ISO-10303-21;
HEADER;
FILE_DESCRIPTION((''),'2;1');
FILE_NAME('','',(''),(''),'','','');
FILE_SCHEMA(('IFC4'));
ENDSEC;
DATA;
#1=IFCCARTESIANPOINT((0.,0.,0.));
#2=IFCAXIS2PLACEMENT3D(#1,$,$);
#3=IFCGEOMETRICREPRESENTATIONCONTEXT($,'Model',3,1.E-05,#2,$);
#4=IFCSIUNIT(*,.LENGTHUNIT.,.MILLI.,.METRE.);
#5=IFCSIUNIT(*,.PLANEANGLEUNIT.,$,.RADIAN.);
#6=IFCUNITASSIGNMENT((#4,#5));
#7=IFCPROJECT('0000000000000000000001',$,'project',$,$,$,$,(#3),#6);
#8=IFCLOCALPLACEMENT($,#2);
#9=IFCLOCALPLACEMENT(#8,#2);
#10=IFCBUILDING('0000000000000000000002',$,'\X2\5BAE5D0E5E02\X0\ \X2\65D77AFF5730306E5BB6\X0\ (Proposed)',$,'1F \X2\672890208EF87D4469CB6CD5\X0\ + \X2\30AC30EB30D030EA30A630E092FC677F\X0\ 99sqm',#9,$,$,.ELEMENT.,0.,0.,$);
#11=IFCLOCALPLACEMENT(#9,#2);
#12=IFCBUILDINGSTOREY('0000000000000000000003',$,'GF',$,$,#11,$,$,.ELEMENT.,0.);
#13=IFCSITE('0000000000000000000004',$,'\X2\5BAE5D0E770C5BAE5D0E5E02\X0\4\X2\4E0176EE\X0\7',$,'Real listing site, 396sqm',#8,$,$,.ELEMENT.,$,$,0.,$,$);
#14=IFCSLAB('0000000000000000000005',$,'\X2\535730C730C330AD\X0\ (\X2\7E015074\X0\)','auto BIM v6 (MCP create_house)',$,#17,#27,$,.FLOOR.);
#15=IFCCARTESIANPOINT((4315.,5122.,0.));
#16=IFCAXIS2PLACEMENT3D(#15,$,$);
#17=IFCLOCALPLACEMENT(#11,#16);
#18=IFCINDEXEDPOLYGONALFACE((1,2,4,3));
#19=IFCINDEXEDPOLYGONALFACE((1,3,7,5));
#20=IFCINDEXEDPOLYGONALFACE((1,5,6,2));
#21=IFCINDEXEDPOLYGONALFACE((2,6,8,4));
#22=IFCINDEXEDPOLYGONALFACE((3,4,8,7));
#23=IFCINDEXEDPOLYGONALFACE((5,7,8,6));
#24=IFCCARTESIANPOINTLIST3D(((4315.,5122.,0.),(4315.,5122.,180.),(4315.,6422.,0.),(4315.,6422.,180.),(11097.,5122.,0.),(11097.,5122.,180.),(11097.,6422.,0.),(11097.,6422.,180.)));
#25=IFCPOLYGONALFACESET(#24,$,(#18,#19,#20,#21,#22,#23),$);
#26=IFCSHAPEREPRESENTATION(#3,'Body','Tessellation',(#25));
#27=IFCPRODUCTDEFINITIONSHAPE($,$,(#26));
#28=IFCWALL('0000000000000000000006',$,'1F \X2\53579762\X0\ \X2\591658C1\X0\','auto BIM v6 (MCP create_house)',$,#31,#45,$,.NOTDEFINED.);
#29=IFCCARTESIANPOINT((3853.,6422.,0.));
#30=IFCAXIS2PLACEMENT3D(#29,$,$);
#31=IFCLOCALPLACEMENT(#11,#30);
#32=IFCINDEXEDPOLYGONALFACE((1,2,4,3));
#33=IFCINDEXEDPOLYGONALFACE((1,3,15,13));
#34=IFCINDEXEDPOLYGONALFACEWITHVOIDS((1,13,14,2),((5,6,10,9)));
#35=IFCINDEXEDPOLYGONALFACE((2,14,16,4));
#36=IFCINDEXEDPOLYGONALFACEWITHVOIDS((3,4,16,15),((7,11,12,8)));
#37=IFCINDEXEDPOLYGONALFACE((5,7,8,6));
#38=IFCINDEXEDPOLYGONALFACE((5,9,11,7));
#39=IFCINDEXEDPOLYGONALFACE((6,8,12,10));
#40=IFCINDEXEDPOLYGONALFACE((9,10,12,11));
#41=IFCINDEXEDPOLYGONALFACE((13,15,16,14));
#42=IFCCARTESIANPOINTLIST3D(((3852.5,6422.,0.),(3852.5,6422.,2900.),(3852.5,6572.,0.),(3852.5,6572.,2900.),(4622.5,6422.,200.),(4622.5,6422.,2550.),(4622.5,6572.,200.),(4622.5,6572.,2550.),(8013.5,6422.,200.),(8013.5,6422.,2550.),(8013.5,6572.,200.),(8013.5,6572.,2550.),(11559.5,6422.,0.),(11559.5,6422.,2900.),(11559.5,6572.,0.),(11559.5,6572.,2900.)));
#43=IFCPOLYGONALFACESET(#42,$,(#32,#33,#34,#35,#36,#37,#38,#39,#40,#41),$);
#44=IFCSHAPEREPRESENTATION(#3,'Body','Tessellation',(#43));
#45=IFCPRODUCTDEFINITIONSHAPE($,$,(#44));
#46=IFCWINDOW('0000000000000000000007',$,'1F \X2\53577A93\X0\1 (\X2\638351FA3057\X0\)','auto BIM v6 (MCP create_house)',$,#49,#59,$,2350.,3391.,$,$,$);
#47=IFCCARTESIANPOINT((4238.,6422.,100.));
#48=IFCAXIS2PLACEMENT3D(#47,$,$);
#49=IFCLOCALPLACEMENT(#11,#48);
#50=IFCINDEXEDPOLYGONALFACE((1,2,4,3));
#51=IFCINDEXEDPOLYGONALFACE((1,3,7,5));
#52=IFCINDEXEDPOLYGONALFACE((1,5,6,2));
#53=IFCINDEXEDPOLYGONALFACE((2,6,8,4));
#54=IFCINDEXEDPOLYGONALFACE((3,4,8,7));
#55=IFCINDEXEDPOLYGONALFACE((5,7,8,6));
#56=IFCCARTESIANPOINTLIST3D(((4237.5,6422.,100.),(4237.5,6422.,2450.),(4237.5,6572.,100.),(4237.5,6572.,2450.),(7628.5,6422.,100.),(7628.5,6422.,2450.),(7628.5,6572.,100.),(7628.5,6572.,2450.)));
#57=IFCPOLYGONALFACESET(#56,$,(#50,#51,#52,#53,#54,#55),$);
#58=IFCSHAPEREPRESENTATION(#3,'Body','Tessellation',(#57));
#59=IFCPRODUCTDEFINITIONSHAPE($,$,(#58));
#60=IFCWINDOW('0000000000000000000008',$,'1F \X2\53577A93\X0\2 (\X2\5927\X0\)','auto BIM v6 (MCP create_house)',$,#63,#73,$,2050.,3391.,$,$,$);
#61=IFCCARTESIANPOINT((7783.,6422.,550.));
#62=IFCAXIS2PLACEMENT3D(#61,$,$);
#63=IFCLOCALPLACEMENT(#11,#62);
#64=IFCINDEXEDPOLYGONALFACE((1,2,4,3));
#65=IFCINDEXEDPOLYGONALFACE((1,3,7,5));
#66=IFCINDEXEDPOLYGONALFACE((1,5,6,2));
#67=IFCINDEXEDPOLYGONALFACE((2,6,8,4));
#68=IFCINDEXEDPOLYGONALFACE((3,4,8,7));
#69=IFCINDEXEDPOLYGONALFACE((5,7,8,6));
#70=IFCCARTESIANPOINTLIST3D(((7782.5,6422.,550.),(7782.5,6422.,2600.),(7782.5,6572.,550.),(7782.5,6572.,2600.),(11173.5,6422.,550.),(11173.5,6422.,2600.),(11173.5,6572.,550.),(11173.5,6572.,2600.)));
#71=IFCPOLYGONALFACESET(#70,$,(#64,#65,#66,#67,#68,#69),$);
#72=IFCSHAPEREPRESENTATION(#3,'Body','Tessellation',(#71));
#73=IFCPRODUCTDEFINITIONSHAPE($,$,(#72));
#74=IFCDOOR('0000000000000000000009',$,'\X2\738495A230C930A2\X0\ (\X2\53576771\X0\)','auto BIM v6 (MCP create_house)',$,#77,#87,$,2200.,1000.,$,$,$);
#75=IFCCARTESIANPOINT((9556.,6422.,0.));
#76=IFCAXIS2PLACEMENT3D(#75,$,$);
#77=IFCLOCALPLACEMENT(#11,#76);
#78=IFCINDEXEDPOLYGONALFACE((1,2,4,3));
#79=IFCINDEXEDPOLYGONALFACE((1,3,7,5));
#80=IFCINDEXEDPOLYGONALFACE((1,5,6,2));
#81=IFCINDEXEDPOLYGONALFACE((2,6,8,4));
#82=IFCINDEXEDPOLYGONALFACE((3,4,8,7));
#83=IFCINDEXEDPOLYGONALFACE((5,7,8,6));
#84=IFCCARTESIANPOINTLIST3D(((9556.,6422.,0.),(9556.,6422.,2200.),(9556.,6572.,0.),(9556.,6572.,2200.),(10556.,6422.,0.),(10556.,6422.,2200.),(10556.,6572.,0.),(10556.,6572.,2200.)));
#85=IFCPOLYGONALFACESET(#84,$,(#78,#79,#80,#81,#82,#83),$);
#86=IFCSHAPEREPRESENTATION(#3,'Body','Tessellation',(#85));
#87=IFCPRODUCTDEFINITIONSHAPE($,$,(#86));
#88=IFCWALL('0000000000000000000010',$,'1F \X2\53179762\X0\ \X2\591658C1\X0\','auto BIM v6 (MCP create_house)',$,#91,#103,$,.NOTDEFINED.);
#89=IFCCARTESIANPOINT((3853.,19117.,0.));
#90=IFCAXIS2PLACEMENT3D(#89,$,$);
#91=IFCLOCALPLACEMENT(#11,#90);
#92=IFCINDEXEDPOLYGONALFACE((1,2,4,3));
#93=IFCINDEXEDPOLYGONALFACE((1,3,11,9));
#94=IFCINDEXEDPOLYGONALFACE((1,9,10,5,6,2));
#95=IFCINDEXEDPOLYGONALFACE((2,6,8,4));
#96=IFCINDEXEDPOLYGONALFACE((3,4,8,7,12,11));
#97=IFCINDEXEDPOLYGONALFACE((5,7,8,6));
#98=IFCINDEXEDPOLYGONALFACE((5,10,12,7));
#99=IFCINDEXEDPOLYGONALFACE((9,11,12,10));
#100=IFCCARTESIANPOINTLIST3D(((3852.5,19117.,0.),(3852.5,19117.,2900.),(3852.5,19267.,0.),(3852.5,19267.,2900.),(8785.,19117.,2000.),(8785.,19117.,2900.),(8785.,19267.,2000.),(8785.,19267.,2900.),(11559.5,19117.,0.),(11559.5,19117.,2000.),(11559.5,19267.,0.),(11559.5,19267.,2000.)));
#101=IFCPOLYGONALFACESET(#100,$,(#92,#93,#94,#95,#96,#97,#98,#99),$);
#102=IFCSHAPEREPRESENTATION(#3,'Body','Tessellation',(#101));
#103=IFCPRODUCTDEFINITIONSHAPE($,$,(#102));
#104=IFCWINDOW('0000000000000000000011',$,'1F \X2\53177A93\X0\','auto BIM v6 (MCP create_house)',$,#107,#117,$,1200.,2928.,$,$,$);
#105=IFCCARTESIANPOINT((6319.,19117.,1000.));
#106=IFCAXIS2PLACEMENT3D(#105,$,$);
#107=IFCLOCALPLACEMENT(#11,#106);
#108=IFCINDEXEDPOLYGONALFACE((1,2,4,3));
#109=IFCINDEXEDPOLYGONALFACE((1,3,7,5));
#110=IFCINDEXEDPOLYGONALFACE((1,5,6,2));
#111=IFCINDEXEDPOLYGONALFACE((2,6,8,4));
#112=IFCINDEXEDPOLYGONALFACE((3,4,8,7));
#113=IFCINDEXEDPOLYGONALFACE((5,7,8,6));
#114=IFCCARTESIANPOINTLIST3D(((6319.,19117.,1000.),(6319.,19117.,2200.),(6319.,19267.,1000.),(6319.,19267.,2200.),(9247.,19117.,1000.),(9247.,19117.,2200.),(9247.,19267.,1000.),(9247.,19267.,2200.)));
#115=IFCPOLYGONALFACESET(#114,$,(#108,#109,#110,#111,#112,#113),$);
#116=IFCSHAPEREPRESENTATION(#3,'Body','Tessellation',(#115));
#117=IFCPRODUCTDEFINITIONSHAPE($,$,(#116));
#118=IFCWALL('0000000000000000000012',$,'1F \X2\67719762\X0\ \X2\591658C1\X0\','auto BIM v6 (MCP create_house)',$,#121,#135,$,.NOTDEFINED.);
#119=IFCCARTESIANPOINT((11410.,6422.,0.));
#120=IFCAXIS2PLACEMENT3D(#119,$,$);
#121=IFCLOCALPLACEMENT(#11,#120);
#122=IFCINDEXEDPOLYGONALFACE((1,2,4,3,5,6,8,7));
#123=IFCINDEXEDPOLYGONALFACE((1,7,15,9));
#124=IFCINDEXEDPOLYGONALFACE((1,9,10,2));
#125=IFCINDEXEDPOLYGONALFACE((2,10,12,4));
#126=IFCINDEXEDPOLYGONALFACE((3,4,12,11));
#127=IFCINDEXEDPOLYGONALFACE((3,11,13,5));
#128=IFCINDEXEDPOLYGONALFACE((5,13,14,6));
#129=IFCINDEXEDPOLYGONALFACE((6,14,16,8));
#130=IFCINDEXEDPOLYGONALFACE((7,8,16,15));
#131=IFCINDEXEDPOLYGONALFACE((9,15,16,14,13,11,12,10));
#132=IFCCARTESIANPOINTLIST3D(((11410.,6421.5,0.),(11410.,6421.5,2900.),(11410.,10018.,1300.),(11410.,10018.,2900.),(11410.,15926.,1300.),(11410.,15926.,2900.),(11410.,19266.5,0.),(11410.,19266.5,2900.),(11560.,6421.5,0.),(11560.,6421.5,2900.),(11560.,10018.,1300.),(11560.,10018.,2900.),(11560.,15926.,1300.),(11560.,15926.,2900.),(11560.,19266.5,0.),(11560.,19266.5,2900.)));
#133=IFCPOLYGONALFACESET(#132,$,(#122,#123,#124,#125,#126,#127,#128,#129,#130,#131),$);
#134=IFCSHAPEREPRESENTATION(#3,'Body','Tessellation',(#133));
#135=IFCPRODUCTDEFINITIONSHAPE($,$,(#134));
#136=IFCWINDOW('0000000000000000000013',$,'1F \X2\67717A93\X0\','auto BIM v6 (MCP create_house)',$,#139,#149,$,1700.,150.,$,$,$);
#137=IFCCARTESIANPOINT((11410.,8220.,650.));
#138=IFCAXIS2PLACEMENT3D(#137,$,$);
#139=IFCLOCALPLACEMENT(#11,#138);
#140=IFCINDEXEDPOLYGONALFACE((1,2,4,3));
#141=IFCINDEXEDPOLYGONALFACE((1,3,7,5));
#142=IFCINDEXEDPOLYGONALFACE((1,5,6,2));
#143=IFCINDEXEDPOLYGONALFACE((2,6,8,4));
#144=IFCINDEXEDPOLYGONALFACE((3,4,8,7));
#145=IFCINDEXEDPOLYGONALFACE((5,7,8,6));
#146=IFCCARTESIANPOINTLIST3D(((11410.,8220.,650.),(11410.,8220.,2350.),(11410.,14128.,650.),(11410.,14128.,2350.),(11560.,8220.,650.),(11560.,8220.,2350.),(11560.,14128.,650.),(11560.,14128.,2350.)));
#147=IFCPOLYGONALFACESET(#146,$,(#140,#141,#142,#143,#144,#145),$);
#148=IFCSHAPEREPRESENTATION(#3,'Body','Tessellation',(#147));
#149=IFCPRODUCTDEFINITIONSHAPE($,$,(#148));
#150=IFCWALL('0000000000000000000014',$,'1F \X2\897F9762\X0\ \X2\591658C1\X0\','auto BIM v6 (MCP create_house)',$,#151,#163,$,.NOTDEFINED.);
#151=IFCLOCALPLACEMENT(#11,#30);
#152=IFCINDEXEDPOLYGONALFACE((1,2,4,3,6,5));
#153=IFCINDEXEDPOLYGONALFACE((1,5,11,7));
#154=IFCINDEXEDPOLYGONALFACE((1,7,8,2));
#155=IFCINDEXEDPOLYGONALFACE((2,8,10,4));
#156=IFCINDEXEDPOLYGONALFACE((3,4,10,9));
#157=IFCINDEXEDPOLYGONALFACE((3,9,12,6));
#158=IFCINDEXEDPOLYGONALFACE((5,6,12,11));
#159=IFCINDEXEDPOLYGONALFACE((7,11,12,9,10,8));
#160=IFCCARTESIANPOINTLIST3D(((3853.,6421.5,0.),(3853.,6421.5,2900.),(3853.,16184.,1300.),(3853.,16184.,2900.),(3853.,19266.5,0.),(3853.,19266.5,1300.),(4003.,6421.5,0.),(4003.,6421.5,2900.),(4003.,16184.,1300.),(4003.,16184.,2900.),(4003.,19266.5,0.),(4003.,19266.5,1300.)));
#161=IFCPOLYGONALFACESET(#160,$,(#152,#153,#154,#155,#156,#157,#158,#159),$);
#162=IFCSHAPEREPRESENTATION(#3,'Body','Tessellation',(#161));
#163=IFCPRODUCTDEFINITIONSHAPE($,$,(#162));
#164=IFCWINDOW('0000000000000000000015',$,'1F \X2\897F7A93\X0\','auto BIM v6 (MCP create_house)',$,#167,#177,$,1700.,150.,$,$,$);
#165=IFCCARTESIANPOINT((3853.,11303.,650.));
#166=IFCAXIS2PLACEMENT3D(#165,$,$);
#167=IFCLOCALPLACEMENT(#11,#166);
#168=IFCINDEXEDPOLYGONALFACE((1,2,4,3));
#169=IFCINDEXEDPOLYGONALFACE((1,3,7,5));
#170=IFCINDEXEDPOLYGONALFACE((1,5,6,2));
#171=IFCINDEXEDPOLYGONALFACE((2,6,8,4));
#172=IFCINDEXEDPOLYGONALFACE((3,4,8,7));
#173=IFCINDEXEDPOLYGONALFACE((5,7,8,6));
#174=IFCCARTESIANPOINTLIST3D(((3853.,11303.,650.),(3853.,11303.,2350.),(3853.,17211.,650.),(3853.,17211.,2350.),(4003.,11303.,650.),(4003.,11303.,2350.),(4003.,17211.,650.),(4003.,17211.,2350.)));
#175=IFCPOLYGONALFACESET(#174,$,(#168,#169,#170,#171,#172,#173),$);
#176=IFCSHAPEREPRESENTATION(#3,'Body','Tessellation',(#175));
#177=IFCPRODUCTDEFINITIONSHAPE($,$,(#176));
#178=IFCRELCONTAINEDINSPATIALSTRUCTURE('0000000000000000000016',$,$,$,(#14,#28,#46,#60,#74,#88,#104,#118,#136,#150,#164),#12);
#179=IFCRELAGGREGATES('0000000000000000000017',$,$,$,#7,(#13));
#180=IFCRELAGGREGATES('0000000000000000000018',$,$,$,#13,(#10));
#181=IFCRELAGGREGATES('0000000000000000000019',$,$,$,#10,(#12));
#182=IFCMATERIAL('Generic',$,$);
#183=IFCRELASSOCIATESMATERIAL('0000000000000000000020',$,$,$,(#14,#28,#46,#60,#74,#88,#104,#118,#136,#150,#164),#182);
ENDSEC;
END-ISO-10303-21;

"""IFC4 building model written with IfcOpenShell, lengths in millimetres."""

from ifc_helpers import new_model, si_unit, frame, frame_2d, origin, place, context, project, spatial, rectangle, extrude, material, element, fill, save


model = new_model("IFC4")

# Units and contexts
model_context = context("Model", 3, precision=1e-05, world=origin())
ifc_project = project(units=[si_unit("LENGTHUNIT", "METRE", prefix="MILLI"), si_unit("PLANEANGLEUNIT", "RADIAN")], contexts=[model_context])

# Site, building, storey
site_placement = place(None, origin())
site = spatial("IfcSite", under=ifc_project, at=site_placement, Name="宮崎県宮崎市4丁目7", ObjectType="Real listing site, 396sqm", CompositionType="ELEMENT", RefElevation=0.0)
building_placement = place(site_placement, origin())
building = spatial("IfcBuilding", under=site, at=building_placement, Name="宮崎市 旗竿地の家 (Proposed)", ObjectType="1F 木造軸組構法 + ガルバリウム鋼板 99sqm", CompositionType="ELEMENT", ElevationOfRefHeight=0.0, ElevationOfTerrain=0.0)
storey_placement = place(building_placement, origin())
storey = spatial("IfcBuildingStorey", under=building, at=storey_placement, Name="GF", CompositionType="ELEMENT", Elevation=0.0)

# Slab
ifc_material = material(Name="Generic")
slab_1_placement = place(storey_placement, frame((4315.0, 5122.0, 0.0)))
element("IfcSlab", 1, at=slab_1_placement, inside=storey, material=ifc_material, Name="南デッキ (縁側)", Description="auto BIM v6 (MCP create_house)", PredefinedType="FLOOR", context=model_context, shape_type="SweptSolid", body=[
    extrude(rectangle(XDim=6782.0, YDim=1300.0, at=frame_2d((3391.0, 650.0))), frame((4315.0, 5122.0, 0.0)), (0.0, 0.0, 1.0), 180.0),
])

# Wall, openings, windows, door
wall_1_placement = place(storey_placement, frame((3853.0, 6422.0, 0.0)))
wall_1 = element("IfcWall", 2, at=wall_1_placement, inside=storey, material=ifc_material, Name="1F 南面 外壁", Description="auto BIM v6 (MCP create_house)", PredefinedType="NOTDEFINED", context=model_context, shape_type="SweptSolid", body=[
    extrude(rectangle(XDim=7707.0, YDim=150.0, at=frame_2d((3853.0, 75.0))), frame((3853.0, 6422.0, 0.0)), (0.0, 0.0, 1.0), 2900.0),
])
opening_1_placement = place(storey_placement, frame((4238.0, 6422.0, 100.0)))
opening_1 = element("IfcOpeningElement", 3, at=opening_1_placement, cuts=wall_1, PredefinedType="NOTDEFINED", context=model_context, shape_type="SweptSolid", body=[
    extrude(rectangle(XDim=3391.0, YDim=150.0, at=frame_2d((1695.0, 75.0))), frame((4238.0, 6422.0, 100.0)), (0.0, 0.0, 1.0), 2350.0),
])
opening_2_placement = place(storey_placement, frame((7783.0, 6422.0, 550.0)))
opening_2 = element("IfcOpeningElement", 4, at=opening_2_placement, cuts=wall_1, PredefinedType="NOTDEFINED", context=model_context, shape_type="SweptSolid", body=[
    extrude(rectangle(XDim=3391.0, YDim=150.0, at=frame_2d((1695.0, 75.0))), frame((7783.0, 6422.0, 550.0)), (0.0, 0.0, 1.0), 2050.0),
])
opening_3_placement = place(storey_placement, frame((9556.0, 6422.0, 0.0)))
opening_3 = element("IfcOpeningElement", 5, at=opening_3_placement, cuts=wall_1, PredefinedType="NOTDEFINED", context=model_context, shape_type="SweptSolid", body=[
    extrude(rectangle(XDim=1000.0, YDim=150.0, at=frame_2d((500.0, 75.0))), frame((9556.0, 6422.0, 0.0)), (0.0, 0.0, 1.0), 2200.0),
])
window_1_placement = place(storey_placement, frame((4238.0, 6422.0, 100.0)))
window_1 = element("IfcWindow", 6, at=window_1_placement, inside=storey, material=ifc_material, Name="1F 南窓1 (掃出し)", Description="auto BIM v6 (MCP create_house)", OverallHeight=2350.0, OverallWidth=3391.0, context=model_context, shape_type="SweptSolid", body=[
    extrude(rectangle(XDim=3391.0, YDim=150.0, at=frame_2d((1695.0, 75.0))), frame((4238.0, 6422.0, 100.0)), (0.0, 0.0, 1.0), 2350.0),
])
fill(opening_1, window_1)
window_2_placement = place(storey_placement, frame((7783.0, 6422.0, 550.0)))
window_2 = element("IfcWindow", 7, at=window_2_placement, inside=storey, material=ifc_material, Name="1F 南窓2 (大)", Description="auto BIM v6 (MCP create_house)", OverallHeight=2050.0, OverallWidth=3391.0, context=model_context, shape_type="SweptSolid", body=[
    extrude(rectangle(XDim=3391.0, YDim=150.0, at=frame_2d((1695.0, 75.0))), frame((7783.0, 6422.0, 550.0)), (0.0, 0.0, 1.0), 2050.0),
])
fill(opening_2, window_2)
door_placement = place(storey_placement, frame((9556.0, 6422.0, 0.0)))
door = element("IfcDoor", 8, at=door_placement, inside=storey, material=ifc_material, Name="玄関ドア (南東)", Description="auto BIM v6 (MCP create_house)", OverallHeight=2200.0, OverallWidth=1000.0, context=model_context, shape_type="SweptSolid", body=[
    extrude(rectangle(XDim=1000.0, YDim=150.0, at=frame_2d((500.0, 75.0))), frame((9556.0, 6422.0, 0.0)), (0.0, 0.0, 1.0), 2200.0),
])
fill(opening_3, door)

# Walls, openings, windows
wall_2_placement = place(storey_placement, frame((3853.0, 19117.0, 0.0)))
wall_2 = element("IfcWall", 9, at=wall_2_placement, inside=storey, material=ifc_material, Name="1F 北面 外壁", Description="auto BIM v6 (MCP create_house)", PredefinedType="NOTDEFINED", context=model_context, shape_type="SweptSolid", body=[
    extrude(rectangle(XDim=7707.0, YDim=150.0, at=frame_2d((3853.0, 75.0))), frame((3853.0, 19117.0, 0.0)), (0.0, 0.0, 1.0), 2900.0),
])
opening_4_placement = place(storey_placement, frame((6319.0, 19117.0, 1000.0)))
opening_4 = element("IfcOpeningElement", 10, at=opening_4_placement, cuts=wall_2, PredefinedType="NOTDEFINED", context=model_context, shape_type="SweptSolid", body=[
    extrude(rectangle(XDim=2928.0, YDim=150.0, at=frame_2d((1464.0, 75.0))), frame((6319.0, 19117.0, 1000.0)), (0.0, 0.0, 1.0), 1200.0),
])
window_3_placement = place(storey_placement, frame((6319.0, 19117.0, 1000.0)))
window_3 = element("IfcWindow", 11, at=window_3_placement, inside=storey, material=ifc_material, Name="1F 北窓", Description="auto BIM v6 (MCP create_house)", OverallHeight=1200.0, OverallWidth=2928.0, context=model_context, shape_type="SweptSolid", body=[
    extrude(rectangle(XDim=2928.0, YDim=150.0, at=frame_2d((1464.0, 75.0))), frame((6319.0, 19117.0, 1000.0)), (0.0, 0.0, 1.0), 1200.0),
])
fill(opening_4, window_3)
wall_3_placement = place(storey_placement, frame((11410.0, 6422.0, 0.0)))
wall_3 = element("IfcWall", 12, at=wall_3_placement, inside=storey, material=ifc_material, Name="1F 東面 外壁", Description="auto BIM v6 (MCP create_house)", PredefinedType="NOTDEFINED", context=model_context, shape_type="SweptSolid", body=[
    extrude(rectangle(XDim=150.0, YDim=12845.0, at=frame_2d((75.0, 6422.0))), frame((11410.0, 6422.0, 0.0)), (0.0, 0.0, 1.0), 2900.0),
])
opening_5_placement = place(storey_placement, frame((11410.0, 8220.0, 650.0)))
opening_5 = element("IfcOpeningElement", 13, at=opening_5_placement, cuts=wall_3, PredefinedType="NOTDEFINED", context=model_context, shape_type="SweptSolid", body=[
    extrude(rectangle(XDim=150.0, YDim=5908.0, at=frame_2d((75.0, 2954.0))), frame((11410.0, 8220.0, 650.0)), (0.0, 0.0, 1.0), 1700.0),
])
window_4_placement = place(storey_placement, frame((11410.0, 8220.0, 650.0)))
window_4 = element("IfcWindow", 14, at=window_4_placement, inside=storey, material=ifc_material, Name="1F 東窓", Description="auto BIM v6 (MCP create_house)", OverallHeight=1700.0, OverallWidth=150.0, context=model_context, shape_type="SweptSolid", body=[
    extrude(rectangle(XDim=150.0, YDim=5908.0, at=frame_2d((75.0, 2954.0))), frame((11410.0, 8220.0, 650.0)), (0.0, 0.0, 1.0), 1700.0),
])
fill(opening_5, window_4)
wall_4_placement = place(storey_placement, frame((3853.0, 6422.0, 0.0)))
wall_4 = element("IfcWall", 15, at=wall_4_placement, inside=storey, material=ifc_material, Name="1F 西面 外壁", Description="auto BIM v6 (MCP create_house)", PredefinedType="NOTDEFINED", context=model_context, shape_type="SweptSolid", body=[
    extrude(rectangle(XDim=150.0, YDim=12845.0, at=frame_2d((75.0, 6422.0))), frame((3853.0, 6422.0, 0.0)), (0.0, 0.0, 1.0), 2900.0),
])
opening_6_placement = place(storey_placement, frame((3853.0, 11303.0, 650.0)))
opening_6 = element("IfcOpeningElement", 16, at=opening_6_placement, cuts=wall_4, PredefinedType="NOTDEFINED", context=model_context, shape_type="SweptSolid", body=[
    extrude(rectangle(XDim=150.0, YDim=5908.0, at=frame_2d((75.0, 2954.0))), frame((3853.0, 11303.0, 650.0)), (0.0, 0.0, 1.0), 1700.0),
])
window_5_placement = place(storey_placement, frame((3853.0, 11303.0, 650.0)))
window_5 = element("IfcWindow", 17, at=window_5_placement, inside=storey, material=ifc_material, Name="1F 西窓", Description="auto BIM v6 (MCP create_house)", OverallHeight=1700.0, OverallWidth=150.0, context=model_context, shape_type="SweptSolid", body=[
    extrude(rectangle(XDim=150.0, YDim=5908.0, at=frame_2d((75.0, 2954.0))), frame((3853.0, 11303.0, 650.0)), (0.0, 0.0, 1.0), 1700.0),
])
fill(opening_6, window_5)

save(model, "model.ifc")
